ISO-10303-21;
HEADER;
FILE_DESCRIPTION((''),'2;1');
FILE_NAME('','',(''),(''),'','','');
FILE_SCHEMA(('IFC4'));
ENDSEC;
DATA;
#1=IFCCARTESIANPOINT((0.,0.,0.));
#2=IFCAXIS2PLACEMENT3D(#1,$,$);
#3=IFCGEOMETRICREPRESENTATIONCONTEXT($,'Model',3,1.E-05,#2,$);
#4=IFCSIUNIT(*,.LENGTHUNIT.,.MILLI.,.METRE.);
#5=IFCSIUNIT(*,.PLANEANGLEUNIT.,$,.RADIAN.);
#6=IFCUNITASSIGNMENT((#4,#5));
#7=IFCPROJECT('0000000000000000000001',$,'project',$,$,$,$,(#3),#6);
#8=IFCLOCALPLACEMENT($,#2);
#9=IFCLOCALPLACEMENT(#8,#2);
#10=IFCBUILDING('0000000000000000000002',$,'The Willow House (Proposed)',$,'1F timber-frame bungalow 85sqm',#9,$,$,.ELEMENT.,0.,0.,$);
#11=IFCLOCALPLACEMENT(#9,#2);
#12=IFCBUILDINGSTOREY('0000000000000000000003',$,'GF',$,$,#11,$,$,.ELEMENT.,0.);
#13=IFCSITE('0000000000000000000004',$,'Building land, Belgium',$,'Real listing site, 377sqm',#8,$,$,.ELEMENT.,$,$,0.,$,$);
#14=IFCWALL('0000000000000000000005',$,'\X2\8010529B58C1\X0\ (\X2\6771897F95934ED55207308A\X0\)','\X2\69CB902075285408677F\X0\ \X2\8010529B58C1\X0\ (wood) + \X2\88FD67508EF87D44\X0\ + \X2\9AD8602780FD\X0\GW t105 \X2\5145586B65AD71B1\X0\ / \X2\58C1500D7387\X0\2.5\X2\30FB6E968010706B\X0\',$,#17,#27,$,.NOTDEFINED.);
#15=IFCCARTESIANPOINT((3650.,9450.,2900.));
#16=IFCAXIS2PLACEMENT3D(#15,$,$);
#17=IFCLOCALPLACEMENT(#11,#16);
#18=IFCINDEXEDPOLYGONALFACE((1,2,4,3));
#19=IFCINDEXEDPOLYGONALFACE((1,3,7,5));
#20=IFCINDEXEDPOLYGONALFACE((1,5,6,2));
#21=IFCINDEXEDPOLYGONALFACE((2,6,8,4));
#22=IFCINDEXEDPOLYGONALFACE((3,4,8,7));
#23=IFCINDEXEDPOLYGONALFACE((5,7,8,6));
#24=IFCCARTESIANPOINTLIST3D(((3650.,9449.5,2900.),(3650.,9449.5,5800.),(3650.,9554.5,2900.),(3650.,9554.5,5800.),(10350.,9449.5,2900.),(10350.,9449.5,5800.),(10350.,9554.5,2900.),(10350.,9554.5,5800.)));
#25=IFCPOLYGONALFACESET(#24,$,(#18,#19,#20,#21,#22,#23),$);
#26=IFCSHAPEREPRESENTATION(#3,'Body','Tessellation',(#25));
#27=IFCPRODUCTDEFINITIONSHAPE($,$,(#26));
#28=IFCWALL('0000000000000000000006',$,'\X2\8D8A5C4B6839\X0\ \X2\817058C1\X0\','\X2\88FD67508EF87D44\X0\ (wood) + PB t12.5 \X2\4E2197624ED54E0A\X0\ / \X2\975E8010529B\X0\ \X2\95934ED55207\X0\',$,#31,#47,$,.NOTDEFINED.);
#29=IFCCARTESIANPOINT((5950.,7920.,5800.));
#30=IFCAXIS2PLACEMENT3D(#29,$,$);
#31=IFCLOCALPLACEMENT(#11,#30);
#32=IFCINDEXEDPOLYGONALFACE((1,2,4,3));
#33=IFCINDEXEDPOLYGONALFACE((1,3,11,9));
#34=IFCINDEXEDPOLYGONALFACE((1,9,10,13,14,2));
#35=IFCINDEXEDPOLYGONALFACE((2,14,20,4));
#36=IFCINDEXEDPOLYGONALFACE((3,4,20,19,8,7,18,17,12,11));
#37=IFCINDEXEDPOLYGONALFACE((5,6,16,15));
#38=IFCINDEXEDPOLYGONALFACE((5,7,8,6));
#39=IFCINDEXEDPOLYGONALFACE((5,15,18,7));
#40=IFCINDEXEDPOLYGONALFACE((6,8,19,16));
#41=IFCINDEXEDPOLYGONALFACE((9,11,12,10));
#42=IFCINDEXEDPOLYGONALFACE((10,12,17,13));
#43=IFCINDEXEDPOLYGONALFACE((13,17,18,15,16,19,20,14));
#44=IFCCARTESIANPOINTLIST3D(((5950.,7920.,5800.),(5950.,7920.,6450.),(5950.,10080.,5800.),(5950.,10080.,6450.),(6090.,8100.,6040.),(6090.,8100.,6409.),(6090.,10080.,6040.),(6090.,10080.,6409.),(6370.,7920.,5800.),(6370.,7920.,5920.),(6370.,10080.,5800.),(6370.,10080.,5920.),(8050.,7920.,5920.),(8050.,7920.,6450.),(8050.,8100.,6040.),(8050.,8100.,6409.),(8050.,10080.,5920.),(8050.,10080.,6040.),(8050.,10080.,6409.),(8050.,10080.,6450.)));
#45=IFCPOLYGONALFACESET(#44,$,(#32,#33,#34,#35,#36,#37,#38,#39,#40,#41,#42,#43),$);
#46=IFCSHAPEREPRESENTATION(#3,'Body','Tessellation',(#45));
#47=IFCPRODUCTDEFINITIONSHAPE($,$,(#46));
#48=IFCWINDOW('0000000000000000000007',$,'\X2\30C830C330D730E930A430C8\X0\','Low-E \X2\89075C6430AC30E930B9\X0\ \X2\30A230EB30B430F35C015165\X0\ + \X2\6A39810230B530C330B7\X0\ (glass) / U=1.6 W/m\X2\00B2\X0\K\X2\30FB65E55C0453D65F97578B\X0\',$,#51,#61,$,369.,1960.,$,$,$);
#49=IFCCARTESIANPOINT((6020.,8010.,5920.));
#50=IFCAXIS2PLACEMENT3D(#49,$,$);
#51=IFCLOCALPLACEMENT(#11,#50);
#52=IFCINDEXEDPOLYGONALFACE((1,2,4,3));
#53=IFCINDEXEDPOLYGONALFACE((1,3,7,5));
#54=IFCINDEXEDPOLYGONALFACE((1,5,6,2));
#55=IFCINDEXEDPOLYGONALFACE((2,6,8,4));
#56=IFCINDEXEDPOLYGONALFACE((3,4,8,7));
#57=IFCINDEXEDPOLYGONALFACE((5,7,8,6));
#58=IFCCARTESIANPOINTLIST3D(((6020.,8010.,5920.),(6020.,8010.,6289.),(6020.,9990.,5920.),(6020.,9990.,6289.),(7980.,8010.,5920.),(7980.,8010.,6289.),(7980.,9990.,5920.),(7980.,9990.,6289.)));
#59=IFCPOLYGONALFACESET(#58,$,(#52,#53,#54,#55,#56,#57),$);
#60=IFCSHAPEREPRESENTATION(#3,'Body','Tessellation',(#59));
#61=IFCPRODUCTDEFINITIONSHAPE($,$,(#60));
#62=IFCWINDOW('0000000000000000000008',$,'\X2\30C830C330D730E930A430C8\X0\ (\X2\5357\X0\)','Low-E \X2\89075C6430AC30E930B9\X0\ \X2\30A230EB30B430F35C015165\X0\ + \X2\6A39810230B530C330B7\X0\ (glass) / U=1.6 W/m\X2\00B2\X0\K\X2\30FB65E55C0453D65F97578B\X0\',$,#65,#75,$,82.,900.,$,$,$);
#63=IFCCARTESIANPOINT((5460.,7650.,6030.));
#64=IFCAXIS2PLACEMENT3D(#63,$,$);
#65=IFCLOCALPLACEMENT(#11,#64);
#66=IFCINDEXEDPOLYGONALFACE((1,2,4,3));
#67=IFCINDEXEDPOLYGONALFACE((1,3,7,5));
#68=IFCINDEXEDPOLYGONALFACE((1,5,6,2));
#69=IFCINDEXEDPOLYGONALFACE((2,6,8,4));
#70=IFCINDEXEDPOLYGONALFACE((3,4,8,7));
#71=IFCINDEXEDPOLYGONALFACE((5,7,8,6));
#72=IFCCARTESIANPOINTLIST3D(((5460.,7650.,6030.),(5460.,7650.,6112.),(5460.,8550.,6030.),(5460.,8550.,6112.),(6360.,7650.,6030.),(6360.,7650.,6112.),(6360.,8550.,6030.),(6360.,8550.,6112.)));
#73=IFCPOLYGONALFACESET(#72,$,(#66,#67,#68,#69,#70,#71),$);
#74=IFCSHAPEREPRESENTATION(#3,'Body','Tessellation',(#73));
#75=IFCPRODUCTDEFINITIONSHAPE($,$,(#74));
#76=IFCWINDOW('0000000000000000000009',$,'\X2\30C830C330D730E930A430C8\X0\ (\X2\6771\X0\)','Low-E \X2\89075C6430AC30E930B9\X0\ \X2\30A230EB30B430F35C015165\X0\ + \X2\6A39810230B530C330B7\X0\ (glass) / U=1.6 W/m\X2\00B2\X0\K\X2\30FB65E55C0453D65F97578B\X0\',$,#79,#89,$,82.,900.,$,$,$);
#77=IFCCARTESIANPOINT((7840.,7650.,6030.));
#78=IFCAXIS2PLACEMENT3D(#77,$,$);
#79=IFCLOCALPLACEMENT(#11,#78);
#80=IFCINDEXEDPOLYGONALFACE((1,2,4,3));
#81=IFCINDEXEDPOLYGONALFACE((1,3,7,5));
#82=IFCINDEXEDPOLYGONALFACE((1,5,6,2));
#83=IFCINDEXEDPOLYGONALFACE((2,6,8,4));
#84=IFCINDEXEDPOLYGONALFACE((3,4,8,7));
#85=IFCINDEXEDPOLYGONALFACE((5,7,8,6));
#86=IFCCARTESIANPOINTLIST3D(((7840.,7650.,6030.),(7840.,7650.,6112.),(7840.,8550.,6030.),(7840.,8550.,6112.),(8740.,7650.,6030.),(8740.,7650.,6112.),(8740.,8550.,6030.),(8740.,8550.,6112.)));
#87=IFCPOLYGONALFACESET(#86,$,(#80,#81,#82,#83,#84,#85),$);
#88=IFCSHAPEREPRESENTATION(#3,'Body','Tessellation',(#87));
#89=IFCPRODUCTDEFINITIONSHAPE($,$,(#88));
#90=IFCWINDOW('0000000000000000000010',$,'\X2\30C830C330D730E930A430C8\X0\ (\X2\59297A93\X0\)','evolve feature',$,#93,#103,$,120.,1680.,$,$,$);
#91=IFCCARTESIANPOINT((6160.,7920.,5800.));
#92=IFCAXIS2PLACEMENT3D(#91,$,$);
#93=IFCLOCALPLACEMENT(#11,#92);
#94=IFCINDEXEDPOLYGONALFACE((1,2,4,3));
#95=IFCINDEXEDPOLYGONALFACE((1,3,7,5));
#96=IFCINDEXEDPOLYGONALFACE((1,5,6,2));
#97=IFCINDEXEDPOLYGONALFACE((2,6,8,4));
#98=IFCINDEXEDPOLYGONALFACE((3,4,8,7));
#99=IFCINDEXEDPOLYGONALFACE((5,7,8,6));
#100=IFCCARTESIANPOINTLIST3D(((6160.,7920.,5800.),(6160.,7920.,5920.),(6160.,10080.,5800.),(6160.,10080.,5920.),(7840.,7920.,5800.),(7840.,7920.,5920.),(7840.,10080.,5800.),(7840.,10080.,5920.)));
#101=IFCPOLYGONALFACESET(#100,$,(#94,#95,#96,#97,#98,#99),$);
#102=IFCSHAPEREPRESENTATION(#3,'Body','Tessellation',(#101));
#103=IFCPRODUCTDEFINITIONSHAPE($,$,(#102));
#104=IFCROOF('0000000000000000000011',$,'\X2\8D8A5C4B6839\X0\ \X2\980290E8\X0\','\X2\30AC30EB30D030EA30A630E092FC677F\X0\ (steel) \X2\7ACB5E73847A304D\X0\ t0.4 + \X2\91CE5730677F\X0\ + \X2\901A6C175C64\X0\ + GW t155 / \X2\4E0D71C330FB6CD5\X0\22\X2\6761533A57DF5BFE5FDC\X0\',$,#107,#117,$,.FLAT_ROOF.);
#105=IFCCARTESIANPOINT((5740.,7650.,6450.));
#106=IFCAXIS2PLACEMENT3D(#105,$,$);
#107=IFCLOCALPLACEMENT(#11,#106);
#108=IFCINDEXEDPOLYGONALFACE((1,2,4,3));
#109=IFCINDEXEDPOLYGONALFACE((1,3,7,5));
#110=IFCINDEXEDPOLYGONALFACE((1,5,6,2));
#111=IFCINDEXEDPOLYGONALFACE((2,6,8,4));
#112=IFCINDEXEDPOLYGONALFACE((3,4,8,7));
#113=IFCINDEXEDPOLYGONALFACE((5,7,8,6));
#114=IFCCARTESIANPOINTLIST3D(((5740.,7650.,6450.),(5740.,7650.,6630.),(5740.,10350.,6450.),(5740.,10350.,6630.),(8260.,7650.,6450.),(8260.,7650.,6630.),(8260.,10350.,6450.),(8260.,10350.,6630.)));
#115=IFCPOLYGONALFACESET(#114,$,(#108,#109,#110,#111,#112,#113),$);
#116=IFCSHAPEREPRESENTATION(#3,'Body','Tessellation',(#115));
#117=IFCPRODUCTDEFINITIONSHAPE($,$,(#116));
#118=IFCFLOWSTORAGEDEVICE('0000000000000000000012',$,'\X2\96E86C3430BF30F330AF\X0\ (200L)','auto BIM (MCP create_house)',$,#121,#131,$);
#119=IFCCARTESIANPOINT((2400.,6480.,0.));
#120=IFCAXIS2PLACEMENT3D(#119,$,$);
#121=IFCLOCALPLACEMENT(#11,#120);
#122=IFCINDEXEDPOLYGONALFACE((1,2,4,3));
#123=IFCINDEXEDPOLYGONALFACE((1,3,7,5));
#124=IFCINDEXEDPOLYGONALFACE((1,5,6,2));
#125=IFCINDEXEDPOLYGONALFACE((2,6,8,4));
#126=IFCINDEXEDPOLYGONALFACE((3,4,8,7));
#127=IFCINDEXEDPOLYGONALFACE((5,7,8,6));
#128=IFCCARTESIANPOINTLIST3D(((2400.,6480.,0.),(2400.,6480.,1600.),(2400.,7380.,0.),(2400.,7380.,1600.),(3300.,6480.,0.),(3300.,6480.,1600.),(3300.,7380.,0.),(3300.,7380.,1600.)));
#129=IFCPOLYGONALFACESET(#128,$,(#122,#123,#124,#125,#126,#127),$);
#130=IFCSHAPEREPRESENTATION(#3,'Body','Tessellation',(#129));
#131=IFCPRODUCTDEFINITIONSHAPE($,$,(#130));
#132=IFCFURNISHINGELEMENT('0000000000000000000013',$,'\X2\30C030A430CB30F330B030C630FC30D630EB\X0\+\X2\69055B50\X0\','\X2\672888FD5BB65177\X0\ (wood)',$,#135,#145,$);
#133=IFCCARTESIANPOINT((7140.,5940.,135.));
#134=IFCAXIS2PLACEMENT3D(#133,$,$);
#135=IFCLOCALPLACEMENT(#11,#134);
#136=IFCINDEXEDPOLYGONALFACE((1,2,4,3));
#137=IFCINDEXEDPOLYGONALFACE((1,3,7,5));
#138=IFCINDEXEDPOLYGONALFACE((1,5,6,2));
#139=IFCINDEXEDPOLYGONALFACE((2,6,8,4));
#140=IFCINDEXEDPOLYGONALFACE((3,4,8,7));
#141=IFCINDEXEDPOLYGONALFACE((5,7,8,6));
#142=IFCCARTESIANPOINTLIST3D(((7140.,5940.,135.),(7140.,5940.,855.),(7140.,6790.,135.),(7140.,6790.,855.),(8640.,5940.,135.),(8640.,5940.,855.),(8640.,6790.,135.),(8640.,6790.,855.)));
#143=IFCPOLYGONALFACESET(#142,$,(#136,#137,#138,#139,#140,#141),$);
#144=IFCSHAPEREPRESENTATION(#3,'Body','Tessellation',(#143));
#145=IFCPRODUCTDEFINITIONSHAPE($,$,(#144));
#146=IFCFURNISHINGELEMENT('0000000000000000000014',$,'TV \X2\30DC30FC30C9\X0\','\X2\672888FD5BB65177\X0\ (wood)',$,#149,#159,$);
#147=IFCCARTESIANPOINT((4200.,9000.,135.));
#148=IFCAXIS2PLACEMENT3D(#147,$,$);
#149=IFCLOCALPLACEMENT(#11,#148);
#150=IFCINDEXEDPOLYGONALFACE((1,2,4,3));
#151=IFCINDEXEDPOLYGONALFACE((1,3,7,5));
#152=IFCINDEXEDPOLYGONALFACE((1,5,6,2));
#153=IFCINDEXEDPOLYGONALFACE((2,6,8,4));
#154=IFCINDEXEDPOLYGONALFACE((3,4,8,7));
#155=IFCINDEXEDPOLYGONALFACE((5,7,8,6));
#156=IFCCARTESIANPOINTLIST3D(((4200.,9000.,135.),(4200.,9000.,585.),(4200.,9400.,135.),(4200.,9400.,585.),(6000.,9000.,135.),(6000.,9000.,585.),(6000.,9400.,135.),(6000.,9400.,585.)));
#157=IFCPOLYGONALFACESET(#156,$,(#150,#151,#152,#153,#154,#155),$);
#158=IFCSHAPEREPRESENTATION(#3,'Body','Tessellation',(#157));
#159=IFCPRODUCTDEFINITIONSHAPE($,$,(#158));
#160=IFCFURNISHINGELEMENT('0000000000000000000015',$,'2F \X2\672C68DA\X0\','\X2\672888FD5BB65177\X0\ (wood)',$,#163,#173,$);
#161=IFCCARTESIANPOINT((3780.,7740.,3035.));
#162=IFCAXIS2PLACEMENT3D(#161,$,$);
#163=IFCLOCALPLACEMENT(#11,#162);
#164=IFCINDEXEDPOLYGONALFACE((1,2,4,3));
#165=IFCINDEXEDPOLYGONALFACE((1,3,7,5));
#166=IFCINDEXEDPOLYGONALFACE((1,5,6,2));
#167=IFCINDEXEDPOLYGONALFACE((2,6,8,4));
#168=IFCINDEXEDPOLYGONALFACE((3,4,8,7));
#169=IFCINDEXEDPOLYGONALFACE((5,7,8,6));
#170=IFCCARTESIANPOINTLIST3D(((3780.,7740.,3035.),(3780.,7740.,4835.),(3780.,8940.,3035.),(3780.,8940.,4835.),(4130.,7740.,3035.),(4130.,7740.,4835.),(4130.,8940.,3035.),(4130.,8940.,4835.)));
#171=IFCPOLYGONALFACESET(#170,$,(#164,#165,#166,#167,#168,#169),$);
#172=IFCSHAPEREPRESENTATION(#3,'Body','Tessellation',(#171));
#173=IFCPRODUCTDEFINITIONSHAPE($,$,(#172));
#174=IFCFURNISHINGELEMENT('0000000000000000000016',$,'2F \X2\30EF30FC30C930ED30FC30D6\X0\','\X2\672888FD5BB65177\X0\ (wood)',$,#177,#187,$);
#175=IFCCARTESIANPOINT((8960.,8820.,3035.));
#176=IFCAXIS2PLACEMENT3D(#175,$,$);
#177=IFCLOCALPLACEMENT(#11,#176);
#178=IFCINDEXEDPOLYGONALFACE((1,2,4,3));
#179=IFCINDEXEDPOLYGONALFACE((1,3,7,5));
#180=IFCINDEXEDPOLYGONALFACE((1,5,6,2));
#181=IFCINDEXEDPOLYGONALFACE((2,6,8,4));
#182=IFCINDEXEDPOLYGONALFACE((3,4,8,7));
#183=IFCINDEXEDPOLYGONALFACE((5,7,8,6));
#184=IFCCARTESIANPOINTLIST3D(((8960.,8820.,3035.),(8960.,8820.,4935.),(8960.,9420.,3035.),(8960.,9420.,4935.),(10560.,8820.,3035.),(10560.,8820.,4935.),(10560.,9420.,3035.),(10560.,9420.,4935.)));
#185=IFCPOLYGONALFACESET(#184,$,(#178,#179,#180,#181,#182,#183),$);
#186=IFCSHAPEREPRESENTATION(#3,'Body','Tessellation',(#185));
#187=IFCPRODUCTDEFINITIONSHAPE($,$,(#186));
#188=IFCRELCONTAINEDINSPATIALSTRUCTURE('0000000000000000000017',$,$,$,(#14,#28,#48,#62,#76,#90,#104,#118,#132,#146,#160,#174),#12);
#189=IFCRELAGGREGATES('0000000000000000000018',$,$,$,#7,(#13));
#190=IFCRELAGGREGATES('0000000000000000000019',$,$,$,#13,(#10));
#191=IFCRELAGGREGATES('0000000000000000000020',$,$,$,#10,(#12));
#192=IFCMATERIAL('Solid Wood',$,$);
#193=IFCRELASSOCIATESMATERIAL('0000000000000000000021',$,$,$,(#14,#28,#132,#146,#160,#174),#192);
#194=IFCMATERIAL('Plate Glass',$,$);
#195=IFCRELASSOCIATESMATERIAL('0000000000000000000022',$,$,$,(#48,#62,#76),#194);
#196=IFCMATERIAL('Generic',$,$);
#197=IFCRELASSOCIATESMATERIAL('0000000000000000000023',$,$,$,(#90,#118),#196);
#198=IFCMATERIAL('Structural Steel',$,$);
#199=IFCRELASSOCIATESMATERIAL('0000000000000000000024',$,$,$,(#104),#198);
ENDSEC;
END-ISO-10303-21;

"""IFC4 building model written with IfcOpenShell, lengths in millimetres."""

from ifc_helpers import new_model, si_unit, frame, frame_2d, origin, place, context, project, spatial, rectangle, extrude, material, element, fill, save


model = new_model("IFC4")

# Units and contexts
model_context = context("Model", 3, precision=1e-05, world=origin())
ifc_project = project(units=[si_unit("LENGTHUNIT", "METRE", prefix="MILLI"), si_unit("PLANEANGLEUNIT", "RADIAN")], contexts=[model_context])

# Site, building, storey
site_placement = place(None, origin())
site = spatial("IfcSite", under=ifc_project, at=site_placement, Name="Building land, Belgium", ObjectType="Real listing site, 377sqm", CompositionType="ELEMENT", RefElevation=0.0)
building_placement = place(site_placement, origin())
building = spatial("IfcBuilding", under=site, at=building_placement, Name="The Willow House (Proposed)", ObjectType="1F timber-frame bungalow 85sqm", CompositionType="ELEMENT", ElevationOfRefHeight=0.0, ElevationOfTerrain=0.0)
storey_placement = place(building_placement, origin())
storey = spatial("IfcBuildingStorey", under=building, at=storey_placement, Name="GF", CompositionType="ELEMENT", Elevation=0.0)

# Wall
ifc_material_1 = material(Name="Solid Wood")
wall_1_placement = place(storey_placement, frame((3650.0, 9450.0, 2900.0)))
element("IfcWall", 1, at=wall_1_placement, inside=storey, material=ifc_material_1, Name="耐力壁 (東西間仕切り)", Description="構造用合板 耐力壁 (wood) + 製材軸組 + 高性能GW t105 充填断熱 / 壁倍率2.5・準耐火", PredefinedType="NOTDEFINED", context=model_context, shape_type="SweptSolid", body=[
    extrude(rectangle(XDim=6700.0, YDim=105.0, at=frame_2d((3350.0, 52.0))), frame((3650.0, 9450.0, 2900.0)), (0.0, 0.0, 1.0), 2900.0),
])

# Wall, openings, windows
wall_2_placement = place(storey_placement, frame((5950.0, 7920.0, 5800.0)))
wall_2 = element("IfcWall", 2, at=wall_2_placement, inside=storey, material=ifc_material_1, Name="越屋根 腰壁", Description="製材軸組 (wood) + PB t12.5 両面仕上 / 非耐力 間仕切", PredefinedType="NOTDEFINED", context=model_context, shape_type="SweptSolid", body=[
    extrude(rectangle(XDim=2100.0, YDim=2160.0, at=frame_2d((1050.0, 1080.0))), frame((5950.0, 7920.0, 5800.0)), (0.0, 0.0, 1.0), 650.0),
])
opening_1_placement = place(storey_placement, frame((6020.0, 8010.0, 5920.0)))
opening_1 = element("IfcOpeningElement", 3, at=opening_1_placement, cuts=wall_2, PredefinedType="NOTDEFINED", context=model_context, shape_type="SweptSolid", body=[
    extrude(rectangle(XDim=1960.0, YDim=1980.0, at=frame_2d((980.0, 990.0))), frame((6020.0, 8010.0, 5920.0)), (0.0, 0.0, 1.0), 369.0),
])
opening_2_placement = place(storey_placement, frame((5460.0, 7650.0, 6030.0)))
opening_2 = element("IfcOpeningElement", 4, at=opening_2_placement, cuts=wall_2, PredefinedType="NOTDEFINED", context=model_context, shape_type="SweptSolid", body=[
    extrude(rectangle(XDim=900.0, YDim=900.0, at=frame_2d((450.0, 450.0))), frame((5460.0, 7650.0, 6030.0)), (0.0, 0.0, 1.0), 82.0),
])
opening_3_placement = place(storey_placement, frame((7840.0, 7650.0, 6030.0)))
opening_3 = element("IfcOpeningElement", 5, at=opening_3_placement, cuts=wall_2, PredefinedType="NOTDEFINED", context=model_context, shape_type="SweptSolid", body=[
    extrude(rectangle(XDim=900.0, YDim=900.0, at=frame_2d((450.0, 450.0))), frame((7840.0, 7650.0, 6030.0)), (0.0, 0.0, 1.0), 82.0),
])
opening_4_placement = place(storey_placement, frame((6160.0, 7920.0, 5800.0)))
opening_4 = element("IfcOpeningElement", 6, at=opening_4_placement, cuts=wall_2, PredefinedType="NOTDEFINED", context=model_context, shape_type="SweptSolid", body=[
    extrude(rectangle(XDim=1680.0, YDim=2160.0, at=frame_2d((840.0, 1080.0))), frame((6160.0, 7920.0, 5800.0)), (0.0, 0.0, 1.0), 120.0),
])
ifc_material_2 = material(Name="Plate Glass")
window_1_placement = place(storey_placement, frame((6020.0, 8010.0, 5920.0)))
window_1 = element("IfcWindow", 7, at=window_1_placement, inside=storey, material=ifc_material_2, Name="トップライト", Description="Low-E 複層ガラス アルゴン封入 + 樹脂サッシ (glass) / U=1.6 W/m²K・日射取得型", OverallHeight=369.0, OverallWidth=1960.0, context=model_context, shape_type="SweptSolid", body=[
    extrude(rectangle(XDim=1960.0, YDim=1980.0, at=frame_2d((980.0, 990.0))), frame((6020.0, 8010.0, 5920.0)), (0.0, 0.0, 1.0), 369.0),
])
fill(opening_1, window_1)
window_2_placement = place(storey_placement, frame((5460.0, 7650.0, 6030.0)))
window_2 = element("IfcWindow", 8, at=window_2_placement, inside=storey, material=ifc_material_2, Name="トップライト (南)", Description="Low-E 複層ガラス アルゴン封入 + 樹脂サッシ (glass) / U=1.6 W/m²K・日射取得型", OverallHeight=82.0, OverallWidth=900.0, context=model_context, shape_type="SweptSolid", body=[
    extrude(rectangle(XDim=900.0, YDim=900.0, at=frame_2d((450.0, 450.0))), frame((5460.0, 7650.0, 6030.0)), (0.0, 0.0, 1.0), 82.0),
])
fill(opening_2, window_2)
window_3_placement = place(storey_placement, frame((7840.0, 7650.0, 6030.0)))
window_3 = element("IfcWindow", 9, at=window_3_placement, inside=storey, material=ifc_material_2, Name="トップライト (東)", Description="Low-E 複層ガラス アルゴン封入 + 樹脂サッシ (glass) / U=1.6 W/m²K・日射取得型", OverallHeight=82.0, OverallWidth=900.0, context=model_context, shape_type="SweptSolid", body=[
    extrude(rectangle(XDim=900.0, YDim=900.0, at=frame_2d((450.0, 450.0))), frame((7840.0, 7650.0, 6030.0)), (0.0, 0.0, 1.0), 82.0),
])
fill(opening_3, window_3)
ifc_material_3 = material(Name="Generic")
window_4_placement = place(storey_placement, frame((6160.0, 7920.0, 5800.0)))
window_4 = element("IfcWindow", 10, at=window_4_placement, inside=storey, material=ifc_material_3, Name="トップライト (天窓)", Description="evolve feature", OverallHeight=120.0, OverallWidth=1680.0, context=model_context, shape_type="SweptSolid", body=[
    extrude(rectangle(XDim=1680.0, YDim=2160.0, at=frame_2d((840.0, 1080.0))), frame((6160.0, 7920.0, 5800.0)), (0.0, 0.0, 1.0), 120.0),
])
fill(opening_4, window_4)

# Roof
ifc_material_4 = material(Name="Structural Steel")
roof_placement = place(storey_placement, frame((5740.0, 7650.0, 6450.0)))
element("IfcRoof", 11, at=roof_placement, inside=storey, material=ifc_material_4, Name="越屋根 頂部", Description="ガルバリウム鋼板 (steel) 立平葺き t0.4 + 野地板 + 通気層 + GW t155 / 不燃・法22条区域対応", PredefinedType="FLAT_ROOF", context=model_context, shape_type="SweptSolid", body=[
    extrude(rectangle(XDim=2520.0, YDim=2700.0, at=frame_2d((1260.0, 1350.0))), frame((5740.0, 7650.0, 6450.0)), (0.0, 0.0, 1.0), 180.0),
])

# Flow storage device
flow_storage_device_placement = place(storey_placement, frame((2400.0, 6480.0, 0.0)))
element("IfcFlowStorageDevice", 12, at=flow_storage_device_placement, inside=storey, material=ifc_material_3, Name="雨水タンク (200L)", Description="auto BIM (MCP create_house)", context=model_context, shape_type="SweptSolid", body=[
    extrude(rectangle(XDim=900.0, YDim=900.0, at=frame_2d((450.0, 450.0))), frame((2400.0, 6480.0, 0.0)), (0.0, 0.0, 1.0), 1600.0),
])

# Furnishing elements
furnishing_1_placement = place(storey_placement, frame((7140.0, 5940.0, 135.0)))
element("IfcFurnishingElement", 13, at=furnishing_1_placement, inside=storey, material=ifc_material_1, Name="ダイニングテーブル+椅子", Description="木製家具 (wood)", context=model_context, shape_type="SweptSolid", body=[
    extrude(rectangle(XDim=1500.0, YDim=850.0, at=frame_2d((750.0, 425.0))), frame((7140.0, 5940.0, 135.0)), (0.0, 0.0, 1.0), 720.0),
])
furnishing_2_placement = place(storey_placement, frame((4200.0, 9000.0, 135.0)))
element("IfcFurnishingElement", 14, at=furnishing_2_placement, inside=storey, material=ifc_material_1, Name="TV ボード", Description="木製家具 (wood)", context=model_context, shape_type="SweptSolid", body=[
    extrude(rectangle(XDim=1800.0, YDim=400.0, at=frame_2d((900.0, 200.0))), frame((4200.0, 9000.0, 135.0)), (0.0, 0.0, 1.0), 450.0),
])
furnishing_3_placement = place(storey_placement, frame((3780.0, 7740.0, 3035.0)))
element("IfcFurnishingElement", 15, at=furnishing_3_placement, inside=storey, material=ifc_material_1, Name="2F 本棚", Description="木製家具 (wood)", context=model_context, shape_type="SweptSolid", body=[
    extrude(rectangle(XDim=350.0, YDim=1200.0, at=frame_2d((175.0, 600.0))), frame((3780.0, 7740.0, 3035.0)), (0.0, 0.0, 1.0), 1800.0),
])
furnishing_4_placement = place(storey_placement, frame((8960.0, 8820.0, 3035.0)))
element("IfcFurnishingElement", 16, at=furnishing_4_placement, inside=storey, material=ifc_material_1, Name="2F ワードローブ", Description="木製家具 (wood)", context=model_context, shape_type="SweptSolid", body=[
    extrude(rectangle(XDim=1600.0, YDim=600.0, at=frame_2d((800.0, 300.0))), frame((8960.0, 8820.0, 3035.0)), (0.0, 0.0, 1.0), 1900.0),
])

save(model, "model.ifc")
